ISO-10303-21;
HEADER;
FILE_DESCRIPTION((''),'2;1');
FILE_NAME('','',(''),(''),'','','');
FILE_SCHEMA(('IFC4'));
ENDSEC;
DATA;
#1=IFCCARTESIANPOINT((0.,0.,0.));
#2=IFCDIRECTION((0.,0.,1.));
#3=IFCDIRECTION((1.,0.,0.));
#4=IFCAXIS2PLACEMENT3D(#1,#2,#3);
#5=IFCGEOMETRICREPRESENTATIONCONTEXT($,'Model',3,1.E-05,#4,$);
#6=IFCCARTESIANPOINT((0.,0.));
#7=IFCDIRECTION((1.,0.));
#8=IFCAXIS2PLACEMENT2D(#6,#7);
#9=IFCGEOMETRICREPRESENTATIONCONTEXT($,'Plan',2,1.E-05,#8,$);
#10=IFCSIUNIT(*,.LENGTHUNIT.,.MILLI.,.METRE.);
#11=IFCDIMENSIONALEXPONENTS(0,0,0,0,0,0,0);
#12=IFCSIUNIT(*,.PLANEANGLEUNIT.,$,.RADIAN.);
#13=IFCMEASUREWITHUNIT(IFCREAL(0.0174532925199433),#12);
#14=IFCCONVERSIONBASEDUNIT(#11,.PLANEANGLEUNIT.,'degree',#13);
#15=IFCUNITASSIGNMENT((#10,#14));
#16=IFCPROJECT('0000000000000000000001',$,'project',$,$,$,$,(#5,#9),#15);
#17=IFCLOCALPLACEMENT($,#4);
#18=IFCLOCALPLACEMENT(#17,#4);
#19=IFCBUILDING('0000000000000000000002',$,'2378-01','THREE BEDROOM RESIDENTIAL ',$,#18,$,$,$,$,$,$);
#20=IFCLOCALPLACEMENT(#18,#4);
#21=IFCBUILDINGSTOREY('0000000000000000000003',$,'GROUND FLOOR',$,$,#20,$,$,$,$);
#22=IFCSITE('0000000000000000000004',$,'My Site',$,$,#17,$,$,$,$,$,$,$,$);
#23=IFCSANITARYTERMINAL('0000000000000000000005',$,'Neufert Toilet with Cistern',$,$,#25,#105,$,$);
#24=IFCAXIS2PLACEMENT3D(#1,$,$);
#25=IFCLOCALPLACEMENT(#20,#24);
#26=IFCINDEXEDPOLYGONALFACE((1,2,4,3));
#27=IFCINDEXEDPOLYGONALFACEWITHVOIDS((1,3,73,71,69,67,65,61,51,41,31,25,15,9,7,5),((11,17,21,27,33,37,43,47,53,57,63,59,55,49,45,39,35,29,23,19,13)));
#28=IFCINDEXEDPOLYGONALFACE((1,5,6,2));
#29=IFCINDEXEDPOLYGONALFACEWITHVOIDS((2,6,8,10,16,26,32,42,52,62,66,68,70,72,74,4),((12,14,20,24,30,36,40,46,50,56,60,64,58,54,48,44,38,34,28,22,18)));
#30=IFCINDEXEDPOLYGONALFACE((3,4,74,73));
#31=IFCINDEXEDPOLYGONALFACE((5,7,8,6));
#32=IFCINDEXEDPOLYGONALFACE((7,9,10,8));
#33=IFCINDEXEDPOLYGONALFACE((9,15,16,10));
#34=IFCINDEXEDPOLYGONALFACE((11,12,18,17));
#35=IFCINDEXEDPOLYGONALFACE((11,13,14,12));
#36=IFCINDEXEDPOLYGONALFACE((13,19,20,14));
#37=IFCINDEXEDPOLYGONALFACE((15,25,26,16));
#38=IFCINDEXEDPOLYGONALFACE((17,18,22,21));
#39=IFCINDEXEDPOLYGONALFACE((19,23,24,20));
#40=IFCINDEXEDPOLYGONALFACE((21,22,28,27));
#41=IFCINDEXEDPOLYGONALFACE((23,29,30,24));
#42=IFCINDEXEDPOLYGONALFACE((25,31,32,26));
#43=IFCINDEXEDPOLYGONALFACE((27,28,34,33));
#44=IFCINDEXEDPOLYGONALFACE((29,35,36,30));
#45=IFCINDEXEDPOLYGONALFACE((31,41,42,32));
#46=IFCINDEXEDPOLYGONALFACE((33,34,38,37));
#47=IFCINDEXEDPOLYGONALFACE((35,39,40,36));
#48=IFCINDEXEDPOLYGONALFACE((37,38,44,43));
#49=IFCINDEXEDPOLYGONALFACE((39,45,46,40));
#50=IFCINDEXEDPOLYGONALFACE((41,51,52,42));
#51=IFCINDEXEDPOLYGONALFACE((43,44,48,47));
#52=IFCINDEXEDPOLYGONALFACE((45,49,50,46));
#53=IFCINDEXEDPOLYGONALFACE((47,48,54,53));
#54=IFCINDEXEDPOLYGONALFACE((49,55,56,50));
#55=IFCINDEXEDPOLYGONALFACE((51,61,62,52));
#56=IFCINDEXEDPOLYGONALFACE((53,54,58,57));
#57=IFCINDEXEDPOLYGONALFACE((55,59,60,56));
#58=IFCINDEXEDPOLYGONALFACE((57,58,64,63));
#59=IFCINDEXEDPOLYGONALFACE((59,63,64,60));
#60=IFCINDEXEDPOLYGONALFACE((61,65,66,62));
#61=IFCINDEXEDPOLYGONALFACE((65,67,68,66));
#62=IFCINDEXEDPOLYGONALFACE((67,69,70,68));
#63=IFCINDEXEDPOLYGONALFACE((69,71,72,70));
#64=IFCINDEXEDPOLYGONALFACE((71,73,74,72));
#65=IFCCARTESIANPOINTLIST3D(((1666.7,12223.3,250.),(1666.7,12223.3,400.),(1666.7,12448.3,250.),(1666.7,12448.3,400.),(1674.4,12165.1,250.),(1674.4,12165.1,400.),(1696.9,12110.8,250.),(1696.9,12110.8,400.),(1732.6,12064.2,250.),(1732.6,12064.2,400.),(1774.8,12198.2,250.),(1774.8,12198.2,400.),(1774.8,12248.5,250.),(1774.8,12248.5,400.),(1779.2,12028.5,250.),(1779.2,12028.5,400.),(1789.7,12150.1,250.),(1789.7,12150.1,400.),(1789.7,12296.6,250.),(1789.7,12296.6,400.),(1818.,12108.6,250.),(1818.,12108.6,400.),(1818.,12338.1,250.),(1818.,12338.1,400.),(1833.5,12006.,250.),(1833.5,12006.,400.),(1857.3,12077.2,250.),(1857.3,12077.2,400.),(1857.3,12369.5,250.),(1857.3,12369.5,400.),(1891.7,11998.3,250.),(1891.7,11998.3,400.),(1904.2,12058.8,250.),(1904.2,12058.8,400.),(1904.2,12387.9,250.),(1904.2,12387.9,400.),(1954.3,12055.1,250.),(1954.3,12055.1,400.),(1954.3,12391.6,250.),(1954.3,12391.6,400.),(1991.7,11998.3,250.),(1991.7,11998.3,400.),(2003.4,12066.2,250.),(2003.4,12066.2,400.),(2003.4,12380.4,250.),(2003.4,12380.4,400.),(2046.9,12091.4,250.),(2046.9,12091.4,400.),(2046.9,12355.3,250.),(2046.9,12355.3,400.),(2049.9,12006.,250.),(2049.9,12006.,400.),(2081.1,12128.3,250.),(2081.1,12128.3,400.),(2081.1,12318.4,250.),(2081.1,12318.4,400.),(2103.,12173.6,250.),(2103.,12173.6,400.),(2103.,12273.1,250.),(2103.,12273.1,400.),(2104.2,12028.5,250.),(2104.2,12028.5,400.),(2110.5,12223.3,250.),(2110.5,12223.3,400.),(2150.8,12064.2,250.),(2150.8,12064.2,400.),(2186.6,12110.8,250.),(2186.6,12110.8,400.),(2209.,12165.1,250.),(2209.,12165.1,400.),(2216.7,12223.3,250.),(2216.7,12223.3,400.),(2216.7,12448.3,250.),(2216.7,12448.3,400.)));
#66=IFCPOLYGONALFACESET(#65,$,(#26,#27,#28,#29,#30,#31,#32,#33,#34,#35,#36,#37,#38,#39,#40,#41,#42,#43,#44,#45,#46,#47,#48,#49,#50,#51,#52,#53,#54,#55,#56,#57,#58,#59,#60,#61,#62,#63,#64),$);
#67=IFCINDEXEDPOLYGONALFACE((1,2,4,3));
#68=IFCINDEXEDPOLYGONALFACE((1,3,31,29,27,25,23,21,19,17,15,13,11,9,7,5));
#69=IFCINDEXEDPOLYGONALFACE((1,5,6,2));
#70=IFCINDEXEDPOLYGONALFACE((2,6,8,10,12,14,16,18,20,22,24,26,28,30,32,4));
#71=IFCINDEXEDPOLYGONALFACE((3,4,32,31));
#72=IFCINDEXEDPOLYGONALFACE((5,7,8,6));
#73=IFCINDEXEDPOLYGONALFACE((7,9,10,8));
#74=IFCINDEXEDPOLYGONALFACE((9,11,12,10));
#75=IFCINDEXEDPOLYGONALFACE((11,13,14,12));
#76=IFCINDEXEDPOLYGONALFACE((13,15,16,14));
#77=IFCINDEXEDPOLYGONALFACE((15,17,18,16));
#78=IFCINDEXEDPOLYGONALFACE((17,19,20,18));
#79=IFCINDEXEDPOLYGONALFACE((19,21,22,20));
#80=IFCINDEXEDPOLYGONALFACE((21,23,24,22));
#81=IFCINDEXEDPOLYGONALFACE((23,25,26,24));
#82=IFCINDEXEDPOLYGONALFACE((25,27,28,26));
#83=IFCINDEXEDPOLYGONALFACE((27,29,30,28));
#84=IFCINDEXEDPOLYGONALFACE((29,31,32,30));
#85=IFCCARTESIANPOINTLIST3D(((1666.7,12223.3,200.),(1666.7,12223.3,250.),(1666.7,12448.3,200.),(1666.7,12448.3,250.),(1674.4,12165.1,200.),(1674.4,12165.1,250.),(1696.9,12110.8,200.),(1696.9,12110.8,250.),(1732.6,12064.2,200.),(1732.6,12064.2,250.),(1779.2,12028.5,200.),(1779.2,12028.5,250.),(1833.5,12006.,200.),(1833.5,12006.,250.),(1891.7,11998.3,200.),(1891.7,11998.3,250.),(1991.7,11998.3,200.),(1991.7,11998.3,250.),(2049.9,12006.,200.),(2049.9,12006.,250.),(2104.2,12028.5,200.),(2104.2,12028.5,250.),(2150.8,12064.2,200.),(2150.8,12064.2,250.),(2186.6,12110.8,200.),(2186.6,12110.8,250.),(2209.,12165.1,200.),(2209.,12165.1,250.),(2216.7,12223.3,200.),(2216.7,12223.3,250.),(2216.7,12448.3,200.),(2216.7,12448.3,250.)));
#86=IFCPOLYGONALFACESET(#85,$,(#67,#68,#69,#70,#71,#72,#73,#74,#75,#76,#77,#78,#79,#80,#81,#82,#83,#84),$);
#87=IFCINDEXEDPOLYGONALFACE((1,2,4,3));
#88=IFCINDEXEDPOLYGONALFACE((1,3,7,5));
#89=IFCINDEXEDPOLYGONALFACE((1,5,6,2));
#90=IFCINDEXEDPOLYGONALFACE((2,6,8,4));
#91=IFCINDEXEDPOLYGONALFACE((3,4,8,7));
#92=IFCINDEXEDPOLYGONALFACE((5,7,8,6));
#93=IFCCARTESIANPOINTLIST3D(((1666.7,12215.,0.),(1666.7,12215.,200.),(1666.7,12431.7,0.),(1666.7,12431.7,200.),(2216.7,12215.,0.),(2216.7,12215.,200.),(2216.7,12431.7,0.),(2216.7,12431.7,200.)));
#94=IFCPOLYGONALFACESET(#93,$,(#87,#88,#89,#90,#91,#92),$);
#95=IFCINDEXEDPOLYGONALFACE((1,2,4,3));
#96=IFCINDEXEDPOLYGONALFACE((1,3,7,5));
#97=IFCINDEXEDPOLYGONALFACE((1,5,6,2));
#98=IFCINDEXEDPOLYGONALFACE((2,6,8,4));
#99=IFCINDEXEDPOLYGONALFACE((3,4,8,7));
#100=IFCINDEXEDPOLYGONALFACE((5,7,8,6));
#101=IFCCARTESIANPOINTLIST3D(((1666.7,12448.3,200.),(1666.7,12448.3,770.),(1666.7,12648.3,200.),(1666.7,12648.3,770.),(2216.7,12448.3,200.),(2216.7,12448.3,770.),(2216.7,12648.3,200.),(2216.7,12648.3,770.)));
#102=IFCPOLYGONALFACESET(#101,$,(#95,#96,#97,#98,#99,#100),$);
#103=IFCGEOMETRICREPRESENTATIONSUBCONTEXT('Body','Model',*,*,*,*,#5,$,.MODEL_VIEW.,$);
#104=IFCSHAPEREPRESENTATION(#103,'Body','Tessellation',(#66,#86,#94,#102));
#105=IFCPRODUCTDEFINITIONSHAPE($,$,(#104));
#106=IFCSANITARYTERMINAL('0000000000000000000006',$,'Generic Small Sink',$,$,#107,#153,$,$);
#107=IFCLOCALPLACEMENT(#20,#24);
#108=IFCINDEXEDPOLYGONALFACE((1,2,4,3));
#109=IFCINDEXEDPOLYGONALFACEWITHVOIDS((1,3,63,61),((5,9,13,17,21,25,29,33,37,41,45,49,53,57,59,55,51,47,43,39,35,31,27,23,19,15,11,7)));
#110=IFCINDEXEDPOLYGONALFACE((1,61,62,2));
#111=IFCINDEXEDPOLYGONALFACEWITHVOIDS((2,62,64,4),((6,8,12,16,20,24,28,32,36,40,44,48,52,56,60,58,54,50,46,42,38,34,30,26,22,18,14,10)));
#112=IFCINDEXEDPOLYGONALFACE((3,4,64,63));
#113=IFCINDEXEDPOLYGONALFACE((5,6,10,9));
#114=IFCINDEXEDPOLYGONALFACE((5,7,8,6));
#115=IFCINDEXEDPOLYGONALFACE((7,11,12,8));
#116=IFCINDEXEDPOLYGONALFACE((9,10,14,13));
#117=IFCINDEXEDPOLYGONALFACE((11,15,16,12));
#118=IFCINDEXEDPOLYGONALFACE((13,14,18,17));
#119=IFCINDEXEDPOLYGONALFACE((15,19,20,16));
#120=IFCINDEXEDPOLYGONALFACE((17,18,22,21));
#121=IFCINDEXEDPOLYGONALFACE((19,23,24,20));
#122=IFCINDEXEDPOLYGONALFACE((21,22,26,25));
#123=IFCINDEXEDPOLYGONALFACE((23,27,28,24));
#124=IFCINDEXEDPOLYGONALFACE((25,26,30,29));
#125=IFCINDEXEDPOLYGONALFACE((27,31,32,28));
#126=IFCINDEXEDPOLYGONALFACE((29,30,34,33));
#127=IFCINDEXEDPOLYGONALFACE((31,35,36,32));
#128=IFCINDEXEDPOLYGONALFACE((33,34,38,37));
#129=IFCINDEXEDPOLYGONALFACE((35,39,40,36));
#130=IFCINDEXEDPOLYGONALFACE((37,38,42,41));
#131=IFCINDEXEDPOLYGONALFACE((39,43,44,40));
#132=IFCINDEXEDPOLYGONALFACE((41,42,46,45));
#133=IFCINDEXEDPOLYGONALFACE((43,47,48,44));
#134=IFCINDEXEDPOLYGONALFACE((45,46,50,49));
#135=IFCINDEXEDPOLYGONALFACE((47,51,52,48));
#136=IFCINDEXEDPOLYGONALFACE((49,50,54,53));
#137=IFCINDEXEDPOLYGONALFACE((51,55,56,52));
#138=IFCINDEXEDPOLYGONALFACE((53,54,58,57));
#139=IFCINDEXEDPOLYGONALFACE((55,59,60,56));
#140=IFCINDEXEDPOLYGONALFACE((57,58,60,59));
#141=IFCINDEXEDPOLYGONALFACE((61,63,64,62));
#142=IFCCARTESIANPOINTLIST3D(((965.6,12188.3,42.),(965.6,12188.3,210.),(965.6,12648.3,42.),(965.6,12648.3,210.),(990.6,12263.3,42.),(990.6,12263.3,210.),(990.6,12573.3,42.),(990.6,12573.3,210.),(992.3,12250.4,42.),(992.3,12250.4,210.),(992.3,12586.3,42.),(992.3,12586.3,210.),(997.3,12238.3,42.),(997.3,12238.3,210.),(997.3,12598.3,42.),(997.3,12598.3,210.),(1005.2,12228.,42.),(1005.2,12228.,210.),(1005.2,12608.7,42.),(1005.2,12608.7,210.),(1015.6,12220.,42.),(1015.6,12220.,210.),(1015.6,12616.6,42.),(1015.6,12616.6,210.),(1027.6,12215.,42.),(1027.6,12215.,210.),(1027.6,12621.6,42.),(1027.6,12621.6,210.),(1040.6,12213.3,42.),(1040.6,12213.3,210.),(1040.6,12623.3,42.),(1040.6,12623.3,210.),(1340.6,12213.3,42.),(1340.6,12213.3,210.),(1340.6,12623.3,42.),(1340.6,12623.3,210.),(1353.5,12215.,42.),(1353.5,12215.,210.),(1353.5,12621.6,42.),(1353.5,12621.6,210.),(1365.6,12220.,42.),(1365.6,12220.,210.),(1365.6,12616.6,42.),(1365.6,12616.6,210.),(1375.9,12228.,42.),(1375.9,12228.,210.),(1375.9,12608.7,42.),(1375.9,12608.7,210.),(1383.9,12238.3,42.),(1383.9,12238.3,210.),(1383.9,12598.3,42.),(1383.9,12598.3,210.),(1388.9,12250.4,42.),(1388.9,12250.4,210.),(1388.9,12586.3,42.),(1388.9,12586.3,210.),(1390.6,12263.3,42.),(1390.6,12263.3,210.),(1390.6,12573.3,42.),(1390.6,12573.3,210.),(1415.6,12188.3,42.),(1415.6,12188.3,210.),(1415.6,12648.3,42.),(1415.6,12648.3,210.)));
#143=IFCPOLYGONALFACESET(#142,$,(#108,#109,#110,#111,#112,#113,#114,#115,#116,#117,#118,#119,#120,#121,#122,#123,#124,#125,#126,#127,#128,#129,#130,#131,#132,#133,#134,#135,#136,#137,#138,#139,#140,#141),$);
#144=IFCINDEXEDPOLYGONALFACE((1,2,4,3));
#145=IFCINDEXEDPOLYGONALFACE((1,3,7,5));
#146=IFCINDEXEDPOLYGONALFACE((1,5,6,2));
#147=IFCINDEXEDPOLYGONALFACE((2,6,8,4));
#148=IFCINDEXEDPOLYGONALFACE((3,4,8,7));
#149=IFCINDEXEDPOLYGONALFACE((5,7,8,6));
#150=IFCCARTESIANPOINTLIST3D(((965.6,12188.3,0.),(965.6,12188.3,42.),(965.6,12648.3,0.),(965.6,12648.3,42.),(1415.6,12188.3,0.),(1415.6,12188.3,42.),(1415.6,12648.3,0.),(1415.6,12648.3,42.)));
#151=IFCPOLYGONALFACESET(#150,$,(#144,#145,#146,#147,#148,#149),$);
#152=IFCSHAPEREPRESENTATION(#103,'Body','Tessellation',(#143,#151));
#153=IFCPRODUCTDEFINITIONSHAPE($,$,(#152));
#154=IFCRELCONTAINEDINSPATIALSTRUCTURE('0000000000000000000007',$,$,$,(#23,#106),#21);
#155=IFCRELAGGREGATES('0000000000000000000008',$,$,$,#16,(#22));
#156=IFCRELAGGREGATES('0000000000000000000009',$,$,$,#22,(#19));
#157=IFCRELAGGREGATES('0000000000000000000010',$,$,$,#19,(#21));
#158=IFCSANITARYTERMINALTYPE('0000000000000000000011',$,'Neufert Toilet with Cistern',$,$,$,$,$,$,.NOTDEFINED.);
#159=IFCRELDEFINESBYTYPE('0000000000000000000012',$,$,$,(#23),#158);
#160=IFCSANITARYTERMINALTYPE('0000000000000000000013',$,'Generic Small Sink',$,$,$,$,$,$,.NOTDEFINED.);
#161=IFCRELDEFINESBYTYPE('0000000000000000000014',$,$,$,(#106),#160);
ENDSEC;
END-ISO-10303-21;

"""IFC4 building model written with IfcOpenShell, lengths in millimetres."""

from ifc_helpers import new_model, entity, si_unit, converted_unit, frame, frame_2d, origin_with_axes, origin_2d_with_axis, place, context, subcontext, project, spatial, line, arc, indexed_curve, circle_curve, outline, extrude, shape, source, transform, mapped, type_object, type_shapes, element, save


model = new_model("IFC4")

# Units and contexts
model_context = context("Model", 3, precision=1e-05, world=origin_with_axes())
plan_context = context("Plan", 2, precision=1e-05, world=origin_2d_with_axis())
body_context_1 = subcontext(model_context, "Body", "Model", "MODEL_VIEW")
body_context_2 = subcontext(plan_context, "Body", "Plan", "PLAN_VIEW")
ifc_project = project(units=[si_unit("LENGTHUNIT", "METRE", prefix="MILLI"), converted_unit("PLANEANGLEUNIT", "degree", entity("IfcReal", 0.0174532925199433), si_unit("PLANEANGLEUNIT", "RADIAN"), dimensions=[0, 0, 0, 0, 0, 0, 0])], contexts=[model_context, plan_context])

# Site, building, storey
site_placement = place(None, origin_with_axes())
site = spatial("IfcSite", under=ifc_project, at=site_placement, Name="My Site")
building_placement = place(site_placement, origin_with_axes())
building = spatial("IfcBuilding", under=site, at=building_placement, Name="2378-01", Description="THREE BEDROOM RESIDENTIAL ")
storey_placement = place(building_placement, origin_with_axes())
storey = spatial("IfcBuildingStorey", under=building, at=storey_placement, Name="GROUND FLOOR")

# Sanitary terminals
sanitary_terminal_type_1 = type_object("IfcSanitaryTerminalType", Name="Neufert Toilet with Cistern", PredefinedType="NOTDEFINED")
shared_shape_1 = source(origin_with_axes(), body_context_1, "Body", "SweptSolid", [
    extrude(outline(indexed_curve([(-275.0, -200.0), (275.0, -200.0), (275.0, -425.0), (209.1, -584.1), (50.0, -650.0), (-50.0, -650.0), (-209.1, -584.1), (-275.0, -425.0)], segments=[line(1, 2), line(2, 3), arc(3, 4, 5), line(5, 6), arc(6, 7, 8), line(8, 1)]), holes=[circle_curve(frame_2d((0.0, -425.0)), 168.8)]), frame((0.0, 0.0, 250.0), z_axis=(0.0, 0.0, 1.0), x_axis=(1.0, 0.0, 0.0)), (0.0, 0.0, 1.0), 150.0),
    extrude(outline(indexed_curve([(-275.0, -200.0), (275.0, -200.0), (275.0, -425.0), (209.1, -584.1), (50.0, -650.0), (-50.0, -650.0), (-209.1, -584.1), (-275.0, -425.0)], segments=[line(1, 2), line(2, 3), arc(3, 4, 5), line(5, 6), arc(6, 7, 8), line(8, 1)])), frame((0.0, 0.0, 200.0), z_axis=(0.0, 0.0, 1.0), x_axis=(1.0, 0.0, 0.0)), (0.0, 0.0, 1.0), 50.0),
    extrude(outline(indexed_curve([(-275.0, -216.7), (275.0, -216.7), (275.0, -433.3), (-275.0, -433.3)], segments=[line(1, 2, 3, 4, 1)])), origin_with_axes(), (0.0, 0.0, 1.0), 200.0),
    extrude(outline(indexed_curve([(-275.0, 0.0), (275.0, 0.0), (275.0, -200.0), (-275.0, -200.0)], segments=[line(1, 2, 3, 4, 1)])), frame((0.0, 0.0, 200.0), z_axis=(0.0, 0.0, 1.0), x_axis=(1.0, 0.0, 0.0)), (0.0, 0.0, 1.0), 570.0),
])
shared_shape_2 = source(origin_with_axes(), body_context_2, "Body", "Curve2D", [
    entity("IfcIndexedPolyCurve", entity("IfcCartesianPointList2D", [[-275.0, 0.0], [275.0, 0.0], [275.0, -200.0], [-275.0, -200.0]]), [entity("IfcLineIndex", [1, 2, 3, 4, 1])]),
    entity("IfcIndexedPolyCurve", entity("IfcCartesianPointList2D", [[165.0, -200.0], [192.5, -335.0]])),
    entity("IfcTrimmedCurve", entity("IfcEllipse", entity("IfcAxis2Placement2D", entity("IfcCartesianPoint", [0.0, -335.0]), entity("IfcDirection", [1.0, 0.0])), 192.5, 315.0), [entity("IfcCartesianPoint", [-192.5, -335.0])], [entity("IfcCartesianPoint", [192.5, -335.0])], True, "CARTESIAN"),
    entity("IfcIndexedPolyCurve", entity("IfcCartesianPointList2D", [[-165.0, -200.0], [-192.5, -335.0]])),
    entity("IfcEllipse", entity("IfcAxis2Placement2D", entity("IfcCartesianPoint", [0.0, -452.0]), entity("IfcDirection", [1.0, 0.0])), 131.2, 157.5),
    entity("IfcIndexedPolyCurve", entity("IfcCartesianPointList2D", [[-34.4, -452.0], [-34.4, -429.5], [34.4, -429.5], [34.4, -452.0]])),
    entity("IfcTrimmedCurve", entity("IfcEllipse", entity("IfcAxis2Placement2D", entity("IfcCartesianPoint", [0.0, -452.0]), entity("IfcDirection", [1.0, 0.0])), 34.4, 22.5), [entity("IfcCartesianPoint", [-34.4, -452.0])], [entity("IfcCartesianPoint", [34.4, -452.0])], True, "CARTESIAN"),
])
type_shapes(sanitary_terminal_type_1, [shared_shape_1, shared_shape_2])
sanitary_terminal_1_placement = place(storey_placement, frame((1941.7, 12648.3, 0.0), z_axis=(0.0, 0.0, 1.0), x_axis=(1.0, 0.0, 0.0)))
element("IfcSanitaryTerminal", 1, at=sanitary_terminal_1_placement, inside=storey, type_object=sanitary_terminal_type_1, Name="Neufert Toilet with Cistern", shapes=[
    shape(body_context_1, "Body", "MappedRepresentation", [mapped(shared_shape_1, transform((0.0, 0.0, 0.0), x_axis=(1.0, 0.0, 0.0), y_axis=(0.0, 1.0, 0.0), z_axis=(0.0, 0.0, 1.0), scale=1.0))]),
    shape(body_context_2, "Body", "MappedRepresentation", [mapped(shared_shape_2, transform((0.0, 0.0, 0.0), x_axis=(1.0, 0.0, 0.0), y_axis=(0.0, 1.0, 0.0), z_axis=(0.0, 0.0, 1.0), scale=1.0))]),
])
sanitary_terminal_type_2 = type_object("IfcSanitaryTerminalType", Name="Generic Small Sink", PredefinedType="NOTDEFINED")
shared_indexed_poly_curve = entity("IfcIndexedPolyCurve", entity("IfcCartesianPointList2D", [[0.0, 0.0], [450.0, 0.0], [450.0, 460.0], [0.0, 460.0]]), [entity("IfcLineIndex", [1, 2, 3, 4, 1])])
shared_shape_3 = source(origin_with_axes(), body_context_1, "Body", "SweptSolid", [
    entity("IfcExtrudedAreaSolid", entity("IfcArbitraryProfileDefWithVoids", "AREA", None, shared_indexed_poly_curve, [entity("IfcIndexedPolyCurve", entity("IfcCartesianPointList2D", [[25.0, 75.0], [39.6, 39.6], [75.0, 25.0], [375.0, 25.0], [410.4, 39.6], [425.0, 75.0], [425.0, 385.0], [410.4, 420.4], [375.0, 435.0], [75.0, 435.0], [39.6, 420.4], [25.0, 385.0]]), [entity("IfcLineIndex", [12, 1]), entity("IfcArcIndex", [1, 2, 3]), entity("IfcLineIndex", [3, 4]), entity("IfcArcIndex", [4, 5, 6]), entity("IfcLineIndex", [6, 7]), entity("IfcArcIndex", [7, 8, 9]), entity("IfcLineIndex", [9, 10]), entity("IfcArcIndex", [10, 11, 12]), entity("IfcLineIndex", [12, 1])])]), entity("IfcAxis2Placement3D", entity("IfcCartesianPoint", [-225.0, -460.0, 42.0]), entity("IfcDirection", [0.0, 0.0, 1.0]), entity("IfcDirection", [1.0, 0.0, 0.0])), entity("IfcDirection", [0.0, 0.0, 1.0]), 168.0),
    entity("IfcExtrudedAreaSolid", entity("IfcArbitraryClosedProfileDef", "AREA", None, shared_indexed_poly_curve), entity("IfcAxis2Placement3D", entity("IfcCartesianPoint", [-225.0, -460.0, 0.0]), entity("IfcDirection", [0.0, 0.0, 1.0]), entity("IfcDirection", [1.0, 0.0, 0.0])), entity("IfcDirection", [0.0, 0.0, 1.0]), 42.0),
])
shared_shape_4 = source(origin_with_axes(), body_context_2, "Body", "Curve2D", [
    entity("IfcIndexedPolyCurve", entity("IfcCartesianPointList2D", [[-225.0, -460.0], [225.0, -460.0], [225.0, 0.0], [-225.0, 0.0]]), [entity("IfcLineIndex", [1, 2, 3, 4, 1])]),
    entity("IfcIndexedPolyCurve", entity("IfcCartesianPointList2D", [[-200.0, -385.0], [-185.4, -420.4], [-150.0, -435.0], [150.0, -435.0], [185.4, -420.4], [200.0, -385.0], [200.0, -75.0], [185.4, -39.6], [150.0, -25.0], [-150.0, -25.0], [-185.4, -39.6], [-200.0, -75.0]]), [entity("IfcLineIndex", [12, 1]), entity("IfcArcIndex", [1, 2, 3]), entity("IfcLineIndex", [3, 4]), entity("IfcArcIndex", [4, 5, 6]), entity("IfcLineIndex", [6, 7]), entity("IfcArcIndex", [7, 8, 9]), entity("IfcLineIndex", [9, 10]), entity("IfcArcIndex", [10, 11, 12]), entity("IfcLineIndex", [12, 1])]),
    entity("IfcCircle", entity("IfcAxis2Placement2D", entity("IfcCartesianPoint", [0.0, -125.0])), 25.0),
    entity("IfcIndexedPolyCurve", entity("IfcCartesianPointList2D", [[0.0, -12.5], [0.0, -132.5]])),
])
type_shapes(sanitary_terminal_type_2, [shared_shape_3, shared_shape_4])
sanitary_terminal_2_placement = place(storey_placement, frame((1190.6, 12648.3, 0.0), z_axis=(0.0, 0.0, 1.0), x_axis=(1.0, 0.0, 0.0)))
element("IfcSanitaryTerminal", 2, at=sanitary_terminal_2_placement, inside=storey, type_object=sanitary_terminal_type_2, Name="Generic Small Sink", shapes=[
    shape(body_context_1, "Body", "MappedRepresentation", [mapped(shared_shape_3, transform((0.0, 0.0, 0.0), x_axis=(1.0, 0.0, 0.0), y_axis=(0.0, 1.0, 0.0), z_axis=(0.0, 0.0, 1.0), scale=1.0))]),
    shape(body_context_2, "Body", "MappedRepresentation", [mapped(shared_shape_4, transform((0.0, 0.0, 0.0), x_axis=(1.0, 0.0, 0.0), y_axis=(0.0, 1.0, 0.0), z_axis=(0.0, 0.0, 1.0), scale=1.0))]),
])

save(model, "model.ifc")
